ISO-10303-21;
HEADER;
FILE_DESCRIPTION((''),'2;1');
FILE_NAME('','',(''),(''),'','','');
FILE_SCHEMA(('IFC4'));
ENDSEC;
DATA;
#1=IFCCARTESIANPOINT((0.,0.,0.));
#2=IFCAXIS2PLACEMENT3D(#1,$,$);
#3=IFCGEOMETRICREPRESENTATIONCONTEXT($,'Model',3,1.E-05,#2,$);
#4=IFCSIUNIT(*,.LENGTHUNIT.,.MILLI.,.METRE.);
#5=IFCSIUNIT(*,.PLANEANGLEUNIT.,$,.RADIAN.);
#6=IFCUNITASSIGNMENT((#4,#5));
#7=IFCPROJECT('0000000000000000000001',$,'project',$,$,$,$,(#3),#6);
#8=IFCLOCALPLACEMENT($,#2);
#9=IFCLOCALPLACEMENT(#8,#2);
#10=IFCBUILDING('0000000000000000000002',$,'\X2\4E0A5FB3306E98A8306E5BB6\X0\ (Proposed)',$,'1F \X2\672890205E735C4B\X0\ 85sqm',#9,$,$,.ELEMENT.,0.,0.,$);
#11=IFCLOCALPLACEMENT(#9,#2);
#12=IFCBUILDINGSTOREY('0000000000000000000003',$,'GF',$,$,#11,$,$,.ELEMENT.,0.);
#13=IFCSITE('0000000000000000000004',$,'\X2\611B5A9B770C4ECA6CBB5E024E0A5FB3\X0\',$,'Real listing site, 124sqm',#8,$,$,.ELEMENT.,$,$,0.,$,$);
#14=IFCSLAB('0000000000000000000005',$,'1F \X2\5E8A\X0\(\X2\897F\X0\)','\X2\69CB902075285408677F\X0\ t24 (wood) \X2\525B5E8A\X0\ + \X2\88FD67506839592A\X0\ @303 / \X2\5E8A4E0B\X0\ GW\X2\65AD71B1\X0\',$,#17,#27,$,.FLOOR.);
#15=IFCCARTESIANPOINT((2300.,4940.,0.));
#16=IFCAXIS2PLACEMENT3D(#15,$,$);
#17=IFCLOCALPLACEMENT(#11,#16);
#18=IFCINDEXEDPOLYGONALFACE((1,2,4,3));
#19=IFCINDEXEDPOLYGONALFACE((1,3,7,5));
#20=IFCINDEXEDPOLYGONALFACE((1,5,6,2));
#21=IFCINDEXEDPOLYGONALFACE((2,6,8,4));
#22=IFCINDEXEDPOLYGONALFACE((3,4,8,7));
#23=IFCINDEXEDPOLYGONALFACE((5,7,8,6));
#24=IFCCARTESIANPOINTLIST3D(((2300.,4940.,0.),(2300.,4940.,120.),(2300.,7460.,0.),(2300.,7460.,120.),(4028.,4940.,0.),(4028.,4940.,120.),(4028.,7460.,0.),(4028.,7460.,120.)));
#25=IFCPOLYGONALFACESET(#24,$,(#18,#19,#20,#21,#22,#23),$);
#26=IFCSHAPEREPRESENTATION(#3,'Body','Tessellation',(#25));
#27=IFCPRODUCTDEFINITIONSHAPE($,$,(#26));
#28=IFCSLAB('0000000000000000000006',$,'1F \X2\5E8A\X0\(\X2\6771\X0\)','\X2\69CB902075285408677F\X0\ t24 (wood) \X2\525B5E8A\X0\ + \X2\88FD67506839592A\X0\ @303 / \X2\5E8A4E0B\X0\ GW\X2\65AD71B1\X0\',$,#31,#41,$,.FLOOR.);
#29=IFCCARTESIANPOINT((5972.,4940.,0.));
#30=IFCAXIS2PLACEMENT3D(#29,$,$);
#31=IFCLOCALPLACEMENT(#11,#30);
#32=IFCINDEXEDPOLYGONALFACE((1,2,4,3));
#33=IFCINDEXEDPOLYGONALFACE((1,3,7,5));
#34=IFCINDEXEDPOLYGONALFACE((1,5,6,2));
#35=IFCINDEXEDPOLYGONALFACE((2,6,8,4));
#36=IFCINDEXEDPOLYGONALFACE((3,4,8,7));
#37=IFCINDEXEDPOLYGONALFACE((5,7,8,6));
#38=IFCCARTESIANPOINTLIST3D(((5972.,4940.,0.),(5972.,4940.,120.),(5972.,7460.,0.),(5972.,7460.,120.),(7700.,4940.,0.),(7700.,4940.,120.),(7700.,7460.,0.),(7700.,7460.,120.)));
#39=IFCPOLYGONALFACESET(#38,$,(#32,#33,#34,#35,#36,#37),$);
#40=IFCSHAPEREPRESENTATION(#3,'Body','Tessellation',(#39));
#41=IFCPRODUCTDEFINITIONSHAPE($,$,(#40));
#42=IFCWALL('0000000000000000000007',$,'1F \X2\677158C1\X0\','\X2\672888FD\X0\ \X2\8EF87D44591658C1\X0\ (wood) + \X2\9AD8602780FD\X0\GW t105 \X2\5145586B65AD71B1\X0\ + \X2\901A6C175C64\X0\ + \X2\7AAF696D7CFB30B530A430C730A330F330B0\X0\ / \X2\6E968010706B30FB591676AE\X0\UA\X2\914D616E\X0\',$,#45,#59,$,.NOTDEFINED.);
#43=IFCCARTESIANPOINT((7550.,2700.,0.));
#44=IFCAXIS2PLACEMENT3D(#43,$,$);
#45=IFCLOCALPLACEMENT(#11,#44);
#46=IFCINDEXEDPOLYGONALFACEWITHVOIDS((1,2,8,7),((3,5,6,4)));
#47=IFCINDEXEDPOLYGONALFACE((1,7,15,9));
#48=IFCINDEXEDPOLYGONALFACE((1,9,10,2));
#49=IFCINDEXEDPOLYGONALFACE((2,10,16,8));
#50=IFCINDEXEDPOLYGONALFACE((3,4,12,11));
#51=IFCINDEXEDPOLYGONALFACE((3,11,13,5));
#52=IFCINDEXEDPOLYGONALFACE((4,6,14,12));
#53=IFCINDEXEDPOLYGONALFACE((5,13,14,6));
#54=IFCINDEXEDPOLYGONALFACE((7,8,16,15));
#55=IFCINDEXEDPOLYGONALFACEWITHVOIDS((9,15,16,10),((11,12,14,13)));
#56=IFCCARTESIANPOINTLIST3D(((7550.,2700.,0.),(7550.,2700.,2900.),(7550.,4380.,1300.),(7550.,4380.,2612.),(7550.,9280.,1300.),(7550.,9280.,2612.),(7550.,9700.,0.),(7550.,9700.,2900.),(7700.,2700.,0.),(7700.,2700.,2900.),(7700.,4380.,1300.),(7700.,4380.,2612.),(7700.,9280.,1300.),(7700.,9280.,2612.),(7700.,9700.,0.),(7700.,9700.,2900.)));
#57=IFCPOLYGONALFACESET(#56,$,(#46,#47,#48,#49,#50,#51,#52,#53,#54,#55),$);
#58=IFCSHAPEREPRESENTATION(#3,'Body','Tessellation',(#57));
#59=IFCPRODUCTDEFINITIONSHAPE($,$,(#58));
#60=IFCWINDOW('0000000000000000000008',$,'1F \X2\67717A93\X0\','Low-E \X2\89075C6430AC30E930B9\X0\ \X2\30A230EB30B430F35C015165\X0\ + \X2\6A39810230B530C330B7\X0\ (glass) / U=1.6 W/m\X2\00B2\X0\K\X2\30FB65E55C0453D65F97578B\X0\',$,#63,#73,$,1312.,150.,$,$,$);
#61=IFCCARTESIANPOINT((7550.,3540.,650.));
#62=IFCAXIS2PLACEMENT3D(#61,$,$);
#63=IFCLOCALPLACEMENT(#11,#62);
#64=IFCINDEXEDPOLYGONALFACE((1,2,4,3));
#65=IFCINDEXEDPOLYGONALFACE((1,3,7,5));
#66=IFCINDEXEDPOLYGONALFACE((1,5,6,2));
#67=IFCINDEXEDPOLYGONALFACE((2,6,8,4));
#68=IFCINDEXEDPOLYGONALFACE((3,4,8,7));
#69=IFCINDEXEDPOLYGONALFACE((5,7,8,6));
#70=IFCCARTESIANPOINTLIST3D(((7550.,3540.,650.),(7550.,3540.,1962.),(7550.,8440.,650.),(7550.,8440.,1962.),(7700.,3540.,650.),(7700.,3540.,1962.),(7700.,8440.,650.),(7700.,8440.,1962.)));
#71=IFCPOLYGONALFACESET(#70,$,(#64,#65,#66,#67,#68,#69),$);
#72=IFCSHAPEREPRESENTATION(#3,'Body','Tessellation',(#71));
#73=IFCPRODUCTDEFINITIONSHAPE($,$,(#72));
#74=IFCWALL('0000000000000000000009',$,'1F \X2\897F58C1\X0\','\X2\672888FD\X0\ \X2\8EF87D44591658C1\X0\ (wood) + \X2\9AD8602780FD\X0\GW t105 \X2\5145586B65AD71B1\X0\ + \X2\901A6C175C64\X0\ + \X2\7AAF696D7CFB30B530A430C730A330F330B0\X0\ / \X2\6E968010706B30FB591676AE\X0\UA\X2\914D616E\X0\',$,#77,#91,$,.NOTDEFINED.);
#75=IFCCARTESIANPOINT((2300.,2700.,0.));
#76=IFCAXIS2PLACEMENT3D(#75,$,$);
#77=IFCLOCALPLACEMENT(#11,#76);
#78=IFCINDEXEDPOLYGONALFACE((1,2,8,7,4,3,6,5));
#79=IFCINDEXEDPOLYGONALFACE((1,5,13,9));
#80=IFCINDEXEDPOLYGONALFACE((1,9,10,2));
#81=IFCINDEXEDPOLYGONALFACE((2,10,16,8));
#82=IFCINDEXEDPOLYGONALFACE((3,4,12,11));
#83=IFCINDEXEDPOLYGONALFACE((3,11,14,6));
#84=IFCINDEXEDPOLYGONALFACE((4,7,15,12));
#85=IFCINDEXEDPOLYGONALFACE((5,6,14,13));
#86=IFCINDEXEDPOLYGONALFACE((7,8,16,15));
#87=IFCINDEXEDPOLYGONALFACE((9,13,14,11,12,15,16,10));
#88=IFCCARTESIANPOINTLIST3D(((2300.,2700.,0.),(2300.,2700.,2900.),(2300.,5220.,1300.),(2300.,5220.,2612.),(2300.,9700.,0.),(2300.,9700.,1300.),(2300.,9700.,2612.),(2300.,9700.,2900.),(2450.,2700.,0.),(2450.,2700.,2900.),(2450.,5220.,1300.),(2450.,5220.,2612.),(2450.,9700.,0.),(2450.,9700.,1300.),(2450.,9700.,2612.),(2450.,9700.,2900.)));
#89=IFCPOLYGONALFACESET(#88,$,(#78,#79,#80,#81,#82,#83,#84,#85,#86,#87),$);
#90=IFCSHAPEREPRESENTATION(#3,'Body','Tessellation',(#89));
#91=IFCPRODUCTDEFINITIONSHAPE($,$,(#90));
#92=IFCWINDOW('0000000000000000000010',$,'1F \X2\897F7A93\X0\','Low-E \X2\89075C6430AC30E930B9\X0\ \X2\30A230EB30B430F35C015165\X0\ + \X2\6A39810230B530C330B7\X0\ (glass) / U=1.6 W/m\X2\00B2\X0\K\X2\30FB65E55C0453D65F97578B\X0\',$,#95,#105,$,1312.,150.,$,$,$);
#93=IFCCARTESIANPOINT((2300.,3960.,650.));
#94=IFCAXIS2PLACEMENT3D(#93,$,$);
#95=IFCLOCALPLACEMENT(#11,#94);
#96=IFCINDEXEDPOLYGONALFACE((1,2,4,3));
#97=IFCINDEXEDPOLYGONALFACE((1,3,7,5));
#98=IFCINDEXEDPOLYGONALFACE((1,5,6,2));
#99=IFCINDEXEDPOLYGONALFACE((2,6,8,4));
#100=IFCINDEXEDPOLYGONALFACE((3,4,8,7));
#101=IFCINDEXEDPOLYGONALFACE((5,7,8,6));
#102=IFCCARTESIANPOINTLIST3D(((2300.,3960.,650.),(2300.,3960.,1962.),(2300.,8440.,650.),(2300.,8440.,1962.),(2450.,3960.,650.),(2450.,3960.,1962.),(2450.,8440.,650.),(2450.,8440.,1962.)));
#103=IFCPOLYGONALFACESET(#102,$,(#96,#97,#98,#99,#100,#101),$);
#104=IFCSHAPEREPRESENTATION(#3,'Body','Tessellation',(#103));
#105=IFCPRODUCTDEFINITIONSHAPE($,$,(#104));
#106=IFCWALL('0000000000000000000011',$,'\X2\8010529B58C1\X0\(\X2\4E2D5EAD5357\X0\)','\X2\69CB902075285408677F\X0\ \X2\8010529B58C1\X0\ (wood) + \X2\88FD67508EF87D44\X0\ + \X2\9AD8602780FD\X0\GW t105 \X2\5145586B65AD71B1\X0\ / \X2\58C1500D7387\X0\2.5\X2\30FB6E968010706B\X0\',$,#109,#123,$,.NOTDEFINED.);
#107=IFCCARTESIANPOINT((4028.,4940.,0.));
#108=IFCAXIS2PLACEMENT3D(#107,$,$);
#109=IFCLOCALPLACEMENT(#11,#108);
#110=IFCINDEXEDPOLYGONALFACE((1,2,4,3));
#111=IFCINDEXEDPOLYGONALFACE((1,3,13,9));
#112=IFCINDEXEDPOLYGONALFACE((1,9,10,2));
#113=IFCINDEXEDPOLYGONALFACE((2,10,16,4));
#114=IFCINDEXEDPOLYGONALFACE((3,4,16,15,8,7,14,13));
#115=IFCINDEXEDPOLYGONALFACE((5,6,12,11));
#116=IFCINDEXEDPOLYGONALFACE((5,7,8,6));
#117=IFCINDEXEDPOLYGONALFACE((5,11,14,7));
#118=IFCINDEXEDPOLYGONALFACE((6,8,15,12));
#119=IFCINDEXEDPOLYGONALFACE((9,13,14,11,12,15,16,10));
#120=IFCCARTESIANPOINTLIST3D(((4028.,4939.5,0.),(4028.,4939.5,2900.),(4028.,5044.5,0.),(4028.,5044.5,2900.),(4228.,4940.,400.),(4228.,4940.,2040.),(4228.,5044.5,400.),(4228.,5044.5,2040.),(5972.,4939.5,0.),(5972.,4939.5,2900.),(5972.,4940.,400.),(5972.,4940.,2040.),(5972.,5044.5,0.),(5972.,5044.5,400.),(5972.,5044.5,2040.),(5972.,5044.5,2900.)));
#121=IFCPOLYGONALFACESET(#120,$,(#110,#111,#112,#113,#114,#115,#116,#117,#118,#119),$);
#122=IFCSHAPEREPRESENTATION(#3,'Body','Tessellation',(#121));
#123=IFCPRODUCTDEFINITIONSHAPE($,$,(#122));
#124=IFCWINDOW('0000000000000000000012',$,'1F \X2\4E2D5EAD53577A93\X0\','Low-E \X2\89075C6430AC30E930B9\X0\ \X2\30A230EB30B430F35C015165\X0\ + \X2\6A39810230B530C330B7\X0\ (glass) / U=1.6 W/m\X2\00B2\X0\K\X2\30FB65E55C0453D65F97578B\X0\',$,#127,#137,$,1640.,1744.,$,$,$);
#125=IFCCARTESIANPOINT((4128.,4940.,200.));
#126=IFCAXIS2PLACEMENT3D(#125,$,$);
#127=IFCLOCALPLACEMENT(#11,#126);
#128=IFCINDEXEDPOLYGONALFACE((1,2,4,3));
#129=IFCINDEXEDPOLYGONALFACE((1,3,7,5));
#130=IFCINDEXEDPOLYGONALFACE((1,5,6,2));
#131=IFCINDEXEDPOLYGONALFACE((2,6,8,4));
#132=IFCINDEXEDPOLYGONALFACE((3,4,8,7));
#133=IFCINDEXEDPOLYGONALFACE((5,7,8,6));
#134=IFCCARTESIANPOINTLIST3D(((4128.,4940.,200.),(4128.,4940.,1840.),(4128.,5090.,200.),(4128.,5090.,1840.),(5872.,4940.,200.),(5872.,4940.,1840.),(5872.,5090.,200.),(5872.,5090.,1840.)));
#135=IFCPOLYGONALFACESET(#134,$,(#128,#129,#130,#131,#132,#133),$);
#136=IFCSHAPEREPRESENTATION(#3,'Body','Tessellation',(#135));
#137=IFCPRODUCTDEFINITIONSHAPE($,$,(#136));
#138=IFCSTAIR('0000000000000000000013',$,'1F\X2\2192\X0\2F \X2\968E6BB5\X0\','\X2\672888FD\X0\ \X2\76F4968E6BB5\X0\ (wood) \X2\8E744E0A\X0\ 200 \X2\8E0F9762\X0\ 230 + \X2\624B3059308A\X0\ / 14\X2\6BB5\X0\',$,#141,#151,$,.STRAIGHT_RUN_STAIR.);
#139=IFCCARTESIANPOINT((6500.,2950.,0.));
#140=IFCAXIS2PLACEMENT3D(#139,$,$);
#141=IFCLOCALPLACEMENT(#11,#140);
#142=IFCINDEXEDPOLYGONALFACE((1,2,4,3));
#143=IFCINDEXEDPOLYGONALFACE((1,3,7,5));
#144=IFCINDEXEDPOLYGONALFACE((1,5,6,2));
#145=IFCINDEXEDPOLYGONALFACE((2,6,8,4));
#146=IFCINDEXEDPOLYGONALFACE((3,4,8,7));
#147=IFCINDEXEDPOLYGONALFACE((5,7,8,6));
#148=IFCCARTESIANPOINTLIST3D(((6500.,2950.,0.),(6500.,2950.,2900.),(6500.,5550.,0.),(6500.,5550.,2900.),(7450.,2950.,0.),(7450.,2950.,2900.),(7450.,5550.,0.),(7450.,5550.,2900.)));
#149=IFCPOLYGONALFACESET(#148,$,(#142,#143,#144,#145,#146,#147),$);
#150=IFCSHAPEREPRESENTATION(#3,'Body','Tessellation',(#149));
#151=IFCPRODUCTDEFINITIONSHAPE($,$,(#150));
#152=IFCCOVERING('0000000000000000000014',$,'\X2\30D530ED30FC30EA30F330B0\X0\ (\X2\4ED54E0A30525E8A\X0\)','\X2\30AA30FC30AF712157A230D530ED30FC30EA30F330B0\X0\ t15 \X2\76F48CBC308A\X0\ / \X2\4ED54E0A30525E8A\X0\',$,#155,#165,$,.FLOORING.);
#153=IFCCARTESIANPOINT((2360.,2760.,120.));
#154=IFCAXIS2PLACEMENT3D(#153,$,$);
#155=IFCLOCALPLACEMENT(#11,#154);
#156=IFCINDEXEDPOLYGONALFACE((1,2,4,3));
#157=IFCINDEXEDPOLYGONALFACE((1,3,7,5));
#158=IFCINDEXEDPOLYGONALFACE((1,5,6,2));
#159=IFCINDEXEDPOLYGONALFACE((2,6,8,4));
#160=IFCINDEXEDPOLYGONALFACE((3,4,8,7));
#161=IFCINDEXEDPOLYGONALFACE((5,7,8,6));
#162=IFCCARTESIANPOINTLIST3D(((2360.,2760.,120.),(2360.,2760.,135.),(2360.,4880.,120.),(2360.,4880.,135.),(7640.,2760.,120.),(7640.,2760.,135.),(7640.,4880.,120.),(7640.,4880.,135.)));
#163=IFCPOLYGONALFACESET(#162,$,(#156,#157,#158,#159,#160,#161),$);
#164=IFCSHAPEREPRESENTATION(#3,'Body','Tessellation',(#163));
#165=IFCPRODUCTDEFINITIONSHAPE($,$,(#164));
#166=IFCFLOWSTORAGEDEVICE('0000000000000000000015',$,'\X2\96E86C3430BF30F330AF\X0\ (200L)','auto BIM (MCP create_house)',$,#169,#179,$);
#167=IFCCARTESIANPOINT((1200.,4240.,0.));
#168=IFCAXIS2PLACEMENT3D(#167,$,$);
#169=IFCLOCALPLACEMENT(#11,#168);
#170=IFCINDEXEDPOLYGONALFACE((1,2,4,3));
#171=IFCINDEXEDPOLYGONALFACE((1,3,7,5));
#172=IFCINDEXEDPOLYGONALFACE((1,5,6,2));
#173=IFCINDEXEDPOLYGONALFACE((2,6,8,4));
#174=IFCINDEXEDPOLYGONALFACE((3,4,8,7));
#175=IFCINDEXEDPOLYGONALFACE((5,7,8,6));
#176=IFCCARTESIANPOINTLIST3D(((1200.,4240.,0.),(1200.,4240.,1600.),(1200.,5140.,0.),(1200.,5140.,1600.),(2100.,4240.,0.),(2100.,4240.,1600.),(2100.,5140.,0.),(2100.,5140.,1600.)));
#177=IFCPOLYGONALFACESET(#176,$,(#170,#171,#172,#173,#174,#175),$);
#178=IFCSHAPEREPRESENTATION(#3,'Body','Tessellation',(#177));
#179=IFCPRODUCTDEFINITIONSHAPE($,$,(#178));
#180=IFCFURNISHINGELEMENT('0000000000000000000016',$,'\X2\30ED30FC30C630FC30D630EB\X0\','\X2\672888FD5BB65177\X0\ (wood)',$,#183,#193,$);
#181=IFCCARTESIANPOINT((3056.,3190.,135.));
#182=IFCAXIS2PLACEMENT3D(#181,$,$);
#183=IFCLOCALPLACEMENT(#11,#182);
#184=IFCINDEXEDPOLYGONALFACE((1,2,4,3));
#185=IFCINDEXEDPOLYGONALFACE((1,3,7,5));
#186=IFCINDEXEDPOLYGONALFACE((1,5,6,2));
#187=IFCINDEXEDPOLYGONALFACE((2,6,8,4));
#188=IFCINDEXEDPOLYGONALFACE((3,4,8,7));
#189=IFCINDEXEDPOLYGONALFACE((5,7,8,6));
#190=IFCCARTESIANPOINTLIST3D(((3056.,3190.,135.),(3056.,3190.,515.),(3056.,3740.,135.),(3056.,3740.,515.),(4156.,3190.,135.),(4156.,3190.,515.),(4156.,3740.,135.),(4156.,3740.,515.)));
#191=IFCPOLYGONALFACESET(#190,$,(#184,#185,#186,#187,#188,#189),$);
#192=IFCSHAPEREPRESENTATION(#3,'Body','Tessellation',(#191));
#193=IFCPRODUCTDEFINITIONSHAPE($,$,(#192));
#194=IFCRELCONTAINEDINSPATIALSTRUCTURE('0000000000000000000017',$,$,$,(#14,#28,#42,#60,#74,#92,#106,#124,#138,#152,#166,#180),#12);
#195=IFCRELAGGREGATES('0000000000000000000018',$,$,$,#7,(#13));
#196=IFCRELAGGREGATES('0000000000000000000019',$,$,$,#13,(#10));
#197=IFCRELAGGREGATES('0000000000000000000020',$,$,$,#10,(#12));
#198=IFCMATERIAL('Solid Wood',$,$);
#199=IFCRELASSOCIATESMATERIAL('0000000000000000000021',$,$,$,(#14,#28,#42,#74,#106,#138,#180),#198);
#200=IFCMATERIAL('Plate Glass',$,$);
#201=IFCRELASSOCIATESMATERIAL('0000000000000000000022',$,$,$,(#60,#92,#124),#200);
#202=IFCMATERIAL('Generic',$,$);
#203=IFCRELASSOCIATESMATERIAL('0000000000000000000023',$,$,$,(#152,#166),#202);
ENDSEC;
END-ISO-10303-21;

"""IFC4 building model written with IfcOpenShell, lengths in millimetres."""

from ifc_helpers import new_model, si_unit, frame, frame_2d, origin, place, context, project, spatial, rectangle, extrude, material, element, fill, save


model = new_model("IFC4")

# Units and contexts
model_context = context("Model", 3, precision=1e-05, world=origin())
ifc_project = project(units=[si_unit("LENGTHUNIT", "METRE", prefix="MILLI"), si_unit("PLANEANGLEUNIT", "RADIAN")], contexts=[model_context])

# Site, building, storey
site_placement = place(None, origin())
site = spatial("IfcSite", under=ifc_project, at=site_placement, Name="愛媛県今治市上徳", ObjectType="Real listing site, 124sqm", CompositionType="ELEMENT", RefElevation=0.0)
building_placement = place(site_placement, origin())
building = spatial("IfcBuilding", under=site, at=building_placement, Name="上徳の風の家 (Proposed)", ObjectType="1F 木造平屋 85sqm", CompositionType="ELEMENT", ElevationOfRefHeight=0.0, ElevationOfTerrain=0.0)
storey_placement = place(building_placement, origin())
storey = spatial("IfcBuildingStorey", under=building, at=storey_placement, Name="GF", CompositionType="ELEMENT", Elevation=0.0)

# Slabs
ifc_material_1 = material(Name="Solid Wood")
slab_1_placement = place(storey_placement, frame((2300.0, 4940.0, 0.0)))
element("IfcSlab", 1, at=slab_1_placement, inside=storey, material=ifc_material_1, Name="1F 床(西)", Description="構造用合板 t24 (wood) 剛床 + 製材根太 @303 / 床下 GW断熱", PredefinedType="FLOOR", context=model_context, shape_type="SweptSolid", body=[
    extrude(rectangle(XDim=1728.0, YDim=2520.0, at=frame_2d((864.0, 1260.0))), frame((2300.0, 4940.0, 0.0)), (0.0, 0.0, 1.0), 120.0),
])
slab_2_placement = place(storey_placement, frame((5972.0, 4940.0, 0.0)))
element("IfcSlab", 2, at=slab_2_placement, inside=storey, material=ifc_material_1, Name="1F 床(東)", Description="構造用合板 t24 (wood) 剛床 + 製材根太 @303 / 床下 GW断熱", PredefinedType="FLOOR", context=model_context, shape_type="SweptSolid", body=[
    extrude(rectangle(XDim=1728.0, YDim=2520.0, at=frame_2d((864.0, 1260.0))), frame((5972.0, 4940.0, 0.0)), (0.0, 0.0, 1.0), 120.0),
])

# Shared definitions
ifc_material_2 = material(Name="Plate Glass")

# Walls, openings, windows
wall_1_placement = place(storey_placement, frame((7550.0, 2700.0, 0.0)))
wall_1 = element("IfcWall", 3, at=wall_1_placement, inside=storey, material=ifc_material_1, Name="1F 東壁", Description="木製 軸組外壁 (wood) + 高性能GW t105 充填断熱 + 通気層 + 窯業系サイディング / 準耐火・外皮UA配慮", PredefinedType="NOTDEFINED", context=model_context, shape_type="SweptSolid", body=[
    extrude(rectangle(XDim=150.0, YDim=7000.0, at=frame_2d((75.0, 3500.0))), frame((7550.0, 2700.0, 0.0)), (0.0, 0.0, 1.0), 2900.0),
])
opening_1_placement = place(storey_placement, frame((7550.0, 3540.0, 650.0)))
opening_1 = element("IfcOpeningElement", 4, at=opening_1_placement, cuts=wall_1, PredefinedType="NOTDEFINED", context=model_context, shape_type="SweptSolid", body=[
    extrude(rectangle(XDim=150.0, YDim=4900.0, at=frame_2d((75.0, 2450.0))), frame((7550.0, 3540.0, 650.0)), (0.0, 0.0, 1.0), 1312.0),
])
window_1_placement = place(storey_placement, frame((7550.0, 3540.0, 650.0)))
window_1 = element("IfcWindow", 5, at=window_1_placement, inside=storey, material=ifc_material_2, Name="1F 東窓", Description="Low-E 複層ガラス アルゴン封入 + 樹脂サッシ (glass) / U=1.6 W/m²K・日射取得型", OverallHeight=1312.0, OverallWidth=150.0, context=model_context, shape_type="SweptSolid", body=[
    extrude(rectangle(XDim=150.0, YDim=4900.0, at=frame_2d((75.0, 2450.0))), frame((7550.0, 3540.0, 650.0)), (0.0, 0.0, 1.0), 1312.0),
])
fill(opening_1, window_1)
wall_2_placement = place(storey_placement, frame((2300.0, 2700.0, 0.0)))
wall_2 = element("IfcWall", 6, at=wall_2_placement, inside=storey, material=ifc_material_1, Name="1F 西壁", Description="木製 軸組外壁 (wood) + 高性能GW t105 充填断熱 + 通気層 + 窯業系サイディング / 準耐火・外皮UA配慮", PredefinedType="NOTDEFINED", context=model_context, shape_type="SweptSolid", body=[
    extrude(rectangle(XDim=150.0, YDim=7000.0, at=frame_2d((75.0, 3500.0))), frame((2300.0, 2700.0, 0.0)), (0.0, 0.0, 1.0), 2900.0),
])
opening_2_placement = place(storey_placement, frame((2300.0, 3960.0, 650.0)))
opening_2 = element("IfcOpeningElement", 7, at=opening_2_placement, cuts=wall_2, PredefinedType="NOTDEFINED", context=model_context, shape_type="SweptSolid", body=[
    extrude(rectangle(XDim=150.0, YDim=4480.0, at=frame_2d((75.0, 2240.0))), frame((2300.0, 3960.0, 650.0)), (0.0, 0.0, 1.0), 1312.0),
])
window_2_placement = place(storey_placement, frame((2300.0, 3960.0, 650.0)))
window_2 = element("IfcWindow", 8, at=window_2_placement, inside=storey, material=ifc_material_2, Name="1F 西窓", Description="Low-E 複層ガラス アルゴン封入 + 樹脂サッシ (glass) / U=1.6 W/m²K・日射取得型", OverallHeight=1312.0, OverallWidth=150.0, context=model_context, shape_type="SweptSolid", body=[
    extrude(rectangle(XDim=150.0, YDim=4480.0, at=frame_2d((75.0, 2240.0))), frame((2300.0, 3960.0, 650.0)), (0.0, 0.0, 1.0), 1312.0),
])
fill(opening_2, window_2)
wall_3_placement = place(storey_placement, frame((4028.0, 4940.0, 0.0)))
wall_3 = element("IfcWall", 9, at=wall_3_placement, inside=storey, material=ifc_material_1, Name="耐力壁(中庭南)", Description="構造用合板 耐力壁 (wood) + 製材軸組 + 高性能GW t105 充填断熱 / 壁倍率2.5・準耐火", PredefinedType="NOTDEFINED", context=model_context, shape_type="SweptSolid", body=[
    extrude(rectangle(XDim=1944.0, YDim=105.0, at=frame_2d((972.0, 52.0))), frame((4028.0, 4940.0, 0.0)), (0.0, 0.0, 1.0), 2900.0),
])
opening_3_placement = place(storey_placement, frame((4128.0, 4940.0, 200.0)))
opening_3 = element("IfcOpeningElement", 10, at=opening_3_placement, cuts=wall_3, PredefinedType="NOTDEFINED", context=model_context, shape_type="SweptSolid", body=[
    extrude(rectangle(XDim=1744.0, YDim=150.0, at=frame_2d((872.0, 75.0))), frame((4128.0, 4940.0, 200.0)), (0.0, 0.0, 1.0), 1640.0),
])
window_3_placement = place(storey_placement, frame((4128.0, 4940.0, 200.0)))
window_3 = element("IfcWindow", 11, at=window_3_placement, inside=storey, material=ifc_material_2, Name="1F 中庭南窓", Description="Low-E 複層ガラス アルゴン封入 + 樹脂サッシ (glass) / U=1.6 W/m²K・日射取得型", OverallHeight=1640.0, OverallWidth=1744.0, context=model_context, shape_type="SweptSolid", body=[
    extrude(rectangle(XDim=1744.0, YDim=150.0, at=frame_2d((872.0, 75.0))), frame((4128.0, 4940.0, 200.0)), (0.0, 0.0, 1.0), 1640.0),
])
fill(opening_3, window_3)

# Stair
stair_placement = place(storey_placement, frame((6500.0, 2950.0, 0.0)))
element("IfcStair", 12, at=stair_placement, inside=storey, material=ifc_material_1, Name="1F→2F 階段", Description="木製 直階段 (wood) 蹴上 200 踏面 230 + 手すり / 14段", PredefinedType="STRAIGHT_RUN_STAIR", context=model_context, shape_type="SweptSolid", body=[
    extrude(rectangle(XDim=950.0, YDim=2600.0, at=frame_2d((475.0, 1300.0))), frame((6500.0, 2950.0, 0.0)), (0.0, 0.0, 1.0), 2900.0),
])

# Covering
ifc_material_3 = material(Name="Generic")
covering_placement = place(storey_placement, frame((2360.0, 2760.0, 120.0)))
element("IfcCovering", 13, at=covering_placement, inside=storey, material=ifc_material_3, Name="フローリング (仕上げ床)", Description="オーク無垢フローリング t15 直貼り / 仕上げ床", PredefinedType="FLOORING", context=model_context, shape_type="SweptSolid", body=[
    extrude(rectangle(XDim=5280.0, YDim=2120.0, at=frame_2d((2640.0, 1060.0))), frame((2360.0, 2760.0, 120.0)), (0.0, 0.0, 1.0), 15.0),
])

# Flow storage device
flow_storage_device_placement = place(storey_placement, frame((1200.0, 4240.0, 0.0)))
element("IfcFlowStorageDevice", 14, at=flow_storage_device_placement, inside=storey, material=ifc_material_3, Name="雨水タンク (200L)", Description="auto BIM (MCP create_house)", context=model_context, shape_type="SweptSolid", body=[
    extrude(rectangle(XDim=900.0, YDim=900.0, at=frame_2d((450.0, 450.0))), frame((1200.0, 4240.0, 0.0)), (0.0, 0.0, 1.0), 1600.0),
])

# Furnishing element
furnishing_1_placement = place(storey_placement, frame((3056.0, 3190.0, 135.0)))
element("IfcFurnishingElement", 15, at=furnishing_1_placement, inside=storey, material=ifc_material_1, Name="ローテーブル", Description="木製家具 (wood)", context=model_context, shape_type="SweptSolid", body=[
    extrude(rectangle(XDim=1100.0, YDim=550.0, at=frame_2d((550.0, 275.0))), frame((3056.0, 3190.0, 135.0)), (0.0, 0.0, 1.0), 380.0),
])

save(model, "model.ifc")
